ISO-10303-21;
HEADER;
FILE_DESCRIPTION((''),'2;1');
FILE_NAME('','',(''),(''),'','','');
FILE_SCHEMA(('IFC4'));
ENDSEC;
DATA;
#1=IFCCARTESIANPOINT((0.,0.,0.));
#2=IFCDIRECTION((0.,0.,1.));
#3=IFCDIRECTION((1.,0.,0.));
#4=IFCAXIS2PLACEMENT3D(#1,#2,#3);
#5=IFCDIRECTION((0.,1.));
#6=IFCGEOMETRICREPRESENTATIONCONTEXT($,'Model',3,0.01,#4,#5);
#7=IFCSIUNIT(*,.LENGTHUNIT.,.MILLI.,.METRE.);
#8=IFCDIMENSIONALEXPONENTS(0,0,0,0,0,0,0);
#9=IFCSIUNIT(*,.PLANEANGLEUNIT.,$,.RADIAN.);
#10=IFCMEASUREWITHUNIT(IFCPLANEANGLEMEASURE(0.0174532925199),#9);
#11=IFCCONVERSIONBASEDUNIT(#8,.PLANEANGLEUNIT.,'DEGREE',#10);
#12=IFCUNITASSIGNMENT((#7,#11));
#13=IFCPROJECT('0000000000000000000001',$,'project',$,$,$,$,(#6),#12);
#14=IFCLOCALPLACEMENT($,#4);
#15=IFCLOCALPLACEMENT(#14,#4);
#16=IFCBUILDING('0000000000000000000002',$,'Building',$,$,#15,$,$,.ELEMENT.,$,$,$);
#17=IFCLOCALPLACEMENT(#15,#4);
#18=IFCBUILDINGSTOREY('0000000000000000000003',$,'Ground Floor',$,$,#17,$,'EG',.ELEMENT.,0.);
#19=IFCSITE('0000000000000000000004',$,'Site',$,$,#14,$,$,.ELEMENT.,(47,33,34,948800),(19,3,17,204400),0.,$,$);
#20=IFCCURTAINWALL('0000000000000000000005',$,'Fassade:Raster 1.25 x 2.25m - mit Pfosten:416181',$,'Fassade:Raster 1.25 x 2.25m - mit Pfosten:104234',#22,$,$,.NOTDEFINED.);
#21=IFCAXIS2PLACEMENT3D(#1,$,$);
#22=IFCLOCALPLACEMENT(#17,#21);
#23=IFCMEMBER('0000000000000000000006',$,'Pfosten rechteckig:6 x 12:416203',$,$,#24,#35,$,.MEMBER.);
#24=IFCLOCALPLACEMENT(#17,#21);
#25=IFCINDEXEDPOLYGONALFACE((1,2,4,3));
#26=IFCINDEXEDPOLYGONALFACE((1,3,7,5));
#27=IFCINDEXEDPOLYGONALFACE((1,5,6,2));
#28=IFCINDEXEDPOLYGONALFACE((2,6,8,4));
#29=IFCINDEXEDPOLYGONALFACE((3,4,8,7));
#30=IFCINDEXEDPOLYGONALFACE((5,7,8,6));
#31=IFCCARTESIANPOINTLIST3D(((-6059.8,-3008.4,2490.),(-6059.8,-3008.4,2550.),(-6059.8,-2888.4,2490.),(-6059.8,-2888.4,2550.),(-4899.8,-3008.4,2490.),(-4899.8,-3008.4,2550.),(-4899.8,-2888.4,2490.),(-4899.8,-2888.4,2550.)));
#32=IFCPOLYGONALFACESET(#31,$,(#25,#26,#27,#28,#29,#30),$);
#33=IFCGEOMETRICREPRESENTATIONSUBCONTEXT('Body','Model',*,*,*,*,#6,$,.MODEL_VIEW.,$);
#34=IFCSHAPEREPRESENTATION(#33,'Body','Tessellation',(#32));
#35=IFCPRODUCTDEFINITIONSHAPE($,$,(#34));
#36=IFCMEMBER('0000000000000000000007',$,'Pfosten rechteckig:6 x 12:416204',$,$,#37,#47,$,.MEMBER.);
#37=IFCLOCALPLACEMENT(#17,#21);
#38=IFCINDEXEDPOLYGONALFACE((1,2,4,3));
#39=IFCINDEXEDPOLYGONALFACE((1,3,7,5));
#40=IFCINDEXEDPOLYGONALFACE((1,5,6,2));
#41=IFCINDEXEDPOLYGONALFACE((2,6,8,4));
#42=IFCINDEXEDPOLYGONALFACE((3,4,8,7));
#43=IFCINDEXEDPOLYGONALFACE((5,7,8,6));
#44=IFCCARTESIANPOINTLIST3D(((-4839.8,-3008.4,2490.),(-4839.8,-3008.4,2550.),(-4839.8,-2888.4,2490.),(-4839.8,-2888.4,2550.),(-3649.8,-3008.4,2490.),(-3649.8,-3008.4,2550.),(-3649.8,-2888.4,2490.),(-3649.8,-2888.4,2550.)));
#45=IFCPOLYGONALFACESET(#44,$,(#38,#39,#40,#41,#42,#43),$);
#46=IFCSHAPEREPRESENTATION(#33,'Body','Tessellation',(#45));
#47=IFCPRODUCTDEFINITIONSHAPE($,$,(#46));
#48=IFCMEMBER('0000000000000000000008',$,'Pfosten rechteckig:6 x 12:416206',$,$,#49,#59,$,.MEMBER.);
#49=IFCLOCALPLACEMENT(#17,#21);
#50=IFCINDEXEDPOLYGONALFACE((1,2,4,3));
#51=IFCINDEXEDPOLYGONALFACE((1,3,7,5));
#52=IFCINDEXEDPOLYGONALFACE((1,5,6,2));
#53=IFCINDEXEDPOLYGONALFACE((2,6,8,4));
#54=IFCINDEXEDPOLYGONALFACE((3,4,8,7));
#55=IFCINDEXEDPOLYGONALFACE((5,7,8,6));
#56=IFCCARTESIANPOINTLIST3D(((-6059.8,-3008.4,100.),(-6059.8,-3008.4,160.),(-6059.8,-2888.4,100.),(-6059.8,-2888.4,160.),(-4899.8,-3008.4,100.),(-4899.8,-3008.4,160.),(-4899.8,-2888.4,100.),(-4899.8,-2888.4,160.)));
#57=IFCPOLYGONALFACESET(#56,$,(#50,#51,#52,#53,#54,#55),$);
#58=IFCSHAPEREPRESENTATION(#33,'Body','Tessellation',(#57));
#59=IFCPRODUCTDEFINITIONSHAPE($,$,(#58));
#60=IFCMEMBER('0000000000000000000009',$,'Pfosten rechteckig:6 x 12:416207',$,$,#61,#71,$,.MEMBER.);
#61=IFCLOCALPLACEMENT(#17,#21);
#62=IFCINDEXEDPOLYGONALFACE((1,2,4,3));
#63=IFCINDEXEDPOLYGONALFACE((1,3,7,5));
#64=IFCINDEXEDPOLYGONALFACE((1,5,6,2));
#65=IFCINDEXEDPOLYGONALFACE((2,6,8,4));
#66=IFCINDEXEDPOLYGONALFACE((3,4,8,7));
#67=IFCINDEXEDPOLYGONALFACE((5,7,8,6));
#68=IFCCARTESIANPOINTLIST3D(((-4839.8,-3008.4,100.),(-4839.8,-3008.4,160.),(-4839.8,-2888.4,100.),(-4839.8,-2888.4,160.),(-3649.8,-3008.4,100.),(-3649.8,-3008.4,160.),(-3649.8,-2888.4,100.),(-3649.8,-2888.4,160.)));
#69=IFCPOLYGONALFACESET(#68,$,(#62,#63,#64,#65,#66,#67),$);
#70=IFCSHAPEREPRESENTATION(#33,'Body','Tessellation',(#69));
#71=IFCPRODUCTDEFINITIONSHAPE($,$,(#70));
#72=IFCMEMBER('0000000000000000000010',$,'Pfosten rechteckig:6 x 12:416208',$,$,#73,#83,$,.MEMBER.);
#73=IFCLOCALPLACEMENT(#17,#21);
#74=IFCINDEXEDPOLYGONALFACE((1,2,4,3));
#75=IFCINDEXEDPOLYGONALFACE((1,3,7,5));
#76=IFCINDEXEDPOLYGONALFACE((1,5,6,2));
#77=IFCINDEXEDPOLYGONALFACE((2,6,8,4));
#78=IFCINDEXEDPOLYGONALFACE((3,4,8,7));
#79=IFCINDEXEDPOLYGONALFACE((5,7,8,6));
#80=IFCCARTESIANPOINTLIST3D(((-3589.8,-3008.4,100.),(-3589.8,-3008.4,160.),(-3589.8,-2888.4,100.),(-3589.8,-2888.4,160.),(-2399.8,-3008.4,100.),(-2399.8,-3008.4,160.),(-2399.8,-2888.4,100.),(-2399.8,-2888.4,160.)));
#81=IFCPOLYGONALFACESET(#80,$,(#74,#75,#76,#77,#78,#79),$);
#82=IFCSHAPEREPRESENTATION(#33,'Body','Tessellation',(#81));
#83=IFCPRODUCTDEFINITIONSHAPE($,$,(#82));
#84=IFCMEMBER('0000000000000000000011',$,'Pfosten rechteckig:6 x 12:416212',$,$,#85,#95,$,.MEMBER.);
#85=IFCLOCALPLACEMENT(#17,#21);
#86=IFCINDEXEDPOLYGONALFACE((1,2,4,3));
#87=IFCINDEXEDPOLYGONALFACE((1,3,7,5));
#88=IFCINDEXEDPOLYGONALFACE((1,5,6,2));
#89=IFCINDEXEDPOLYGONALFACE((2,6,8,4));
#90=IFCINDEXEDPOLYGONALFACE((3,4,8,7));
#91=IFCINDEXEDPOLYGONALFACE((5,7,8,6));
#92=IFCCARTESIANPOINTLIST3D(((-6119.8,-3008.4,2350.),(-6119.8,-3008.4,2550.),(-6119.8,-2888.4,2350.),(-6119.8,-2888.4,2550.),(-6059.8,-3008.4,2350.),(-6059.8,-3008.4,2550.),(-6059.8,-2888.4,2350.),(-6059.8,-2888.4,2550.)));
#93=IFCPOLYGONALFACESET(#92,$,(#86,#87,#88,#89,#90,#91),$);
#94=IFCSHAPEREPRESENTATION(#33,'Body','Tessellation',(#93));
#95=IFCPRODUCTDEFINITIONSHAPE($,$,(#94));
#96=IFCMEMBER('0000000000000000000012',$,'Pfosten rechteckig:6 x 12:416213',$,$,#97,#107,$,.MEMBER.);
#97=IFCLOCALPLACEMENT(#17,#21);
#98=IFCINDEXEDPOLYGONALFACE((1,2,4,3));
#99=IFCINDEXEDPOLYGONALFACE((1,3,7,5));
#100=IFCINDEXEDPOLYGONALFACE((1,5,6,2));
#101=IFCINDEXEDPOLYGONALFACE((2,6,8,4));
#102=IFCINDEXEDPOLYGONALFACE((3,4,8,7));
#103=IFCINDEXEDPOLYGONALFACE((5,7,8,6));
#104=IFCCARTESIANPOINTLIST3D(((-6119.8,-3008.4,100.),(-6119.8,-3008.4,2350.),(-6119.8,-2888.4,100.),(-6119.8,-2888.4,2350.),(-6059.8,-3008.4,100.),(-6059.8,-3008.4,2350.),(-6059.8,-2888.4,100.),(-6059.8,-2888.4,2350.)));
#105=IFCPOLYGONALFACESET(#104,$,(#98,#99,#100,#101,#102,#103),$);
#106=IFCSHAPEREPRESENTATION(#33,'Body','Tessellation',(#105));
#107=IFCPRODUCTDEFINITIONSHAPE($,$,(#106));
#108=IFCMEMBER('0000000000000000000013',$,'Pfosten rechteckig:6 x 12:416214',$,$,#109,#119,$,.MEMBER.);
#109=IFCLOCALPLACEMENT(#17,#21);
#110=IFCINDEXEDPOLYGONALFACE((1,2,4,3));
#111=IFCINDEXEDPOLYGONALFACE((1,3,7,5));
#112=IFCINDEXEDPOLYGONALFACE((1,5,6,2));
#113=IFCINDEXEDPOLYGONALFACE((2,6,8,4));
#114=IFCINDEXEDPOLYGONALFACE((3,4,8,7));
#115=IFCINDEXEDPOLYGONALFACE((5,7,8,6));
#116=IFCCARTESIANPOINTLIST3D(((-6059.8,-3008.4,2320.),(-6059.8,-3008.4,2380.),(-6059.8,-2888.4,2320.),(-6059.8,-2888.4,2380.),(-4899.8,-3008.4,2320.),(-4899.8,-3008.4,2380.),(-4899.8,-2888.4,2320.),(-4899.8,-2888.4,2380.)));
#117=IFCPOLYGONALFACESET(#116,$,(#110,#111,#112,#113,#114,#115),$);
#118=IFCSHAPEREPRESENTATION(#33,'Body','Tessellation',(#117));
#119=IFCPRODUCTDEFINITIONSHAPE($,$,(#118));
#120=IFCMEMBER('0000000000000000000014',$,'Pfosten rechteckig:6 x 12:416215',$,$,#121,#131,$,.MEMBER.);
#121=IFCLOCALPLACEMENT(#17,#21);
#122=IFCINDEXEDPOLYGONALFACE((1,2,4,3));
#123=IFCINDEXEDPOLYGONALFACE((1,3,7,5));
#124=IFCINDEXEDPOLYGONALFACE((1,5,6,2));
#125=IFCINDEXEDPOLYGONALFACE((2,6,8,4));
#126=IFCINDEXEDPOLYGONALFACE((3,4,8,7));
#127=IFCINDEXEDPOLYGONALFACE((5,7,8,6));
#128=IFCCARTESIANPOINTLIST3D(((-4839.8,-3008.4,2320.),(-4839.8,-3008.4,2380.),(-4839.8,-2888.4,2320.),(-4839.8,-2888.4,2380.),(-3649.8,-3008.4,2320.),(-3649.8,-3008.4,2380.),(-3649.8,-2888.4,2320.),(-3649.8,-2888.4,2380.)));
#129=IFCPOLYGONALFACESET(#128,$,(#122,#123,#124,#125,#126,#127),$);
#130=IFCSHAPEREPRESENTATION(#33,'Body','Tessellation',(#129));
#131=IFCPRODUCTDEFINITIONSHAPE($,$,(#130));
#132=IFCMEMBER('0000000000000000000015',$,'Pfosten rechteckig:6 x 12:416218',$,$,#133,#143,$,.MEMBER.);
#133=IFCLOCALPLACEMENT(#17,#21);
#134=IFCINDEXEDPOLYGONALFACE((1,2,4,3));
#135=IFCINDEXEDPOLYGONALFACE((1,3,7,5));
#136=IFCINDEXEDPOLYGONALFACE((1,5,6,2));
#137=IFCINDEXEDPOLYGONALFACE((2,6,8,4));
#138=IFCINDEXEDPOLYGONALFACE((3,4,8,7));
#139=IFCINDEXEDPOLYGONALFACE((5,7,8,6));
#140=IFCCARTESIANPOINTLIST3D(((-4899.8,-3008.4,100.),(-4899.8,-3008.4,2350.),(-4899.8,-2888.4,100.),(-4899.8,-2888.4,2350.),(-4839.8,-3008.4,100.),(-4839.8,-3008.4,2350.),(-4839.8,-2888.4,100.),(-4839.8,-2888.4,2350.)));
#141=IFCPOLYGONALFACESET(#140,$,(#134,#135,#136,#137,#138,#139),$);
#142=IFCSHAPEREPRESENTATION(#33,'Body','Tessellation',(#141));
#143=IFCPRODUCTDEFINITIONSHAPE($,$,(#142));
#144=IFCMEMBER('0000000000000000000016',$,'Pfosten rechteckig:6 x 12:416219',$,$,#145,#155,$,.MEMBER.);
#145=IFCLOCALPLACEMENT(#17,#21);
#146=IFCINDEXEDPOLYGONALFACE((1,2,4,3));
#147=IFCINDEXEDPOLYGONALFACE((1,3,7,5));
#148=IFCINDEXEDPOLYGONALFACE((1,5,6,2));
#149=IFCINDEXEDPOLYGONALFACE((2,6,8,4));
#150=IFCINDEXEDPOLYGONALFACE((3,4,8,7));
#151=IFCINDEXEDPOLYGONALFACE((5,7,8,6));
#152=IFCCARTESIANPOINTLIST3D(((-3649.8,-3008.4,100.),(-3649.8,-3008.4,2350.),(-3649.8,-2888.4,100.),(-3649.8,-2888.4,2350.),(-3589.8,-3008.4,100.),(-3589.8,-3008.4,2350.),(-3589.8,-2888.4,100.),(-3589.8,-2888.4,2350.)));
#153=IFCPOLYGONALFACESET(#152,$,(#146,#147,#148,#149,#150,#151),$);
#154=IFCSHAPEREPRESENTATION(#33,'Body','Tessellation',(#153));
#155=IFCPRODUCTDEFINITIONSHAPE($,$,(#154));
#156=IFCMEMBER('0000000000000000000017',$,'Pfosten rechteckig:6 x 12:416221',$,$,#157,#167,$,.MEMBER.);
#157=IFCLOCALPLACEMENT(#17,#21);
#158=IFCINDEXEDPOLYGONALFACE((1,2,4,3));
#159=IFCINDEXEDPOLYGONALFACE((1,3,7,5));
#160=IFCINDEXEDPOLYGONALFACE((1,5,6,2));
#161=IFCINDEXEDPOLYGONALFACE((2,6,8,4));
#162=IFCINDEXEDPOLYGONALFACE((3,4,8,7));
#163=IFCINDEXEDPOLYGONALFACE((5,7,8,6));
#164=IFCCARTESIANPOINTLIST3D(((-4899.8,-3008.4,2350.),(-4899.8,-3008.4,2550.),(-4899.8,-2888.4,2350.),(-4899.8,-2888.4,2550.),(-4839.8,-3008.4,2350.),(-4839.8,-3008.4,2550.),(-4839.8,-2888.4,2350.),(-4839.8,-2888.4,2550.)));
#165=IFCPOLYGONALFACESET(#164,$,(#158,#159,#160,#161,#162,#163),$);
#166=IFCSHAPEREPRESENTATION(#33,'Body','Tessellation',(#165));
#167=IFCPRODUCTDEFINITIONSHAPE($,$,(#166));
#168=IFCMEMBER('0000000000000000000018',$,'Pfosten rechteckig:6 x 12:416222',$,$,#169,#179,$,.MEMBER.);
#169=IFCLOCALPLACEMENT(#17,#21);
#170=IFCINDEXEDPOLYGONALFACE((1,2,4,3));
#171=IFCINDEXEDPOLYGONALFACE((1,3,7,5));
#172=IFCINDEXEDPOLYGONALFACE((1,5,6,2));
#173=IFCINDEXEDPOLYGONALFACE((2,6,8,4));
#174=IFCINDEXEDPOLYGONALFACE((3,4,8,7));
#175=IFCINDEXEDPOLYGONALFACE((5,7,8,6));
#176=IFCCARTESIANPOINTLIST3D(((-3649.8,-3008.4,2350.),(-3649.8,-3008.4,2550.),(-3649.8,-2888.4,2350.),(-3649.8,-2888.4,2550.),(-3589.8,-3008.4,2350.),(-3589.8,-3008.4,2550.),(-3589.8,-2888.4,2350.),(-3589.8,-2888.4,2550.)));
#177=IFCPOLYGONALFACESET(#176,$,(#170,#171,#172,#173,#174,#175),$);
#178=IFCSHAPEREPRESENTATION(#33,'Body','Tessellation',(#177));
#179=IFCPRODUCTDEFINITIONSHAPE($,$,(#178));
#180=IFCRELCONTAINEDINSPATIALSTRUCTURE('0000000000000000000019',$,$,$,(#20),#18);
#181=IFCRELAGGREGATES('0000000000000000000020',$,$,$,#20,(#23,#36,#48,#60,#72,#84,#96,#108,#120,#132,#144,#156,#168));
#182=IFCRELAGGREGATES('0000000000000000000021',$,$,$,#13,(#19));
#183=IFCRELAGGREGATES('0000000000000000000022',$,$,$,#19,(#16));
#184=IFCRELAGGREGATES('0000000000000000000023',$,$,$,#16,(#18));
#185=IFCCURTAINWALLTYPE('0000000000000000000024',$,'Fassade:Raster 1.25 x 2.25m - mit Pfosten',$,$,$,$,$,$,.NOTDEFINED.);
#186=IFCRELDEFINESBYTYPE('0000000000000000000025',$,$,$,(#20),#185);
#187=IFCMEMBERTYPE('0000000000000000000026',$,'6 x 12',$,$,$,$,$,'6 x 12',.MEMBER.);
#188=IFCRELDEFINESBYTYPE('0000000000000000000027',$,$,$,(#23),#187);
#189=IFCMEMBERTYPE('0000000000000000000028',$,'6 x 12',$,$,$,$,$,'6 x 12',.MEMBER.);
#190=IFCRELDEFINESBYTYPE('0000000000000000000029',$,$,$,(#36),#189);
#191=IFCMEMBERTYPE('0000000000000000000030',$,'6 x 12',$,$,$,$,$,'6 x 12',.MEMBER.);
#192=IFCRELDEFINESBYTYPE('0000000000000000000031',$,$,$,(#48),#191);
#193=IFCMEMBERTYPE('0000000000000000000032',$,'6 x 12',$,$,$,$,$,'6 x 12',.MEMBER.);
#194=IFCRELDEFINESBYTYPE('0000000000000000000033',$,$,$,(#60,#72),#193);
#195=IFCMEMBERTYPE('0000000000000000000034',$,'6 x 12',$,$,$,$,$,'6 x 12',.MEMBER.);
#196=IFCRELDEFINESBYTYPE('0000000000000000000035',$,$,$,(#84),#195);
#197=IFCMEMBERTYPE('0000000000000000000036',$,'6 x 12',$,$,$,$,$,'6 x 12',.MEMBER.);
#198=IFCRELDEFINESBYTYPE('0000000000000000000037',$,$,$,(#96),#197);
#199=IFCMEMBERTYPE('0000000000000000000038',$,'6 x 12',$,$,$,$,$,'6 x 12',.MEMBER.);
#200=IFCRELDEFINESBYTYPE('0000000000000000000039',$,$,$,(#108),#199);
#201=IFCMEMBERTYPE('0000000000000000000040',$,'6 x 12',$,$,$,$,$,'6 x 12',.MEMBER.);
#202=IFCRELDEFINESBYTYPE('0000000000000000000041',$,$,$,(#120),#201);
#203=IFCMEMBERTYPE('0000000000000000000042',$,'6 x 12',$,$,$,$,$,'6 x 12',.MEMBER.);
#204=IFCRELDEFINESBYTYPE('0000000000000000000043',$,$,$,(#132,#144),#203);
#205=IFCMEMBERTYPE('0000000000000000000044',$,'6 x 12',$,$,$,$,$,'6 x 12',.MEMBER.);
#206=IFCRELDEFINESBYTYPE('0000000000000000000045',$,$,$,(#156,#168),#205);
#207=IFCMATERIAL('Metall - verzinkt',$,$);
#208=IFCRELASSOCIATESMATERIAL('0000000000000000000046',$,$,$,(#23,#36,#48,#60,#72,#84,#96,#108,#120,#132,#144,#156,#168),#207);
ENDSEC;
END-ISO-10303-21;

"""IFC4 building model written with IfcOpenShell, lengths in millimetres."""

from ifc_helpers import new_model, entity, si_unit, converted_unit, direction, frame, origin_with_axes, origin_2d_with_axis, place, context, subcontext, project, spatial, rectangle, extrude, material, type_object, element, aggregate, save


model = new_model("IFC4")

# Units and contexts
model_context = context("Model", 3, precision=0.01, world=origin_with_axes(), true_north=direction((0.0, 1.0)))
body_context = subcontext(model_context, "Body", "Model", "MODEL_VIEW")
ifc_project = project(units=[si_unit("LENGTHUNIT", "METRE", prefix="MILLI"), converted_unit("PLANEANGLEUNIT", "DEGREE", entity("IfcPlaneAngleMeasure", 0.0174532925199), si_unit("PLANEANGLEUNIT", "RADIAN"), dimensions=[0, 0, 0, 0, 0, 0, 0])], contexts=[model_context])

# Site, building, storey
site_placement = place(None, origin_with_axes())
site = spatial("IfcSite", under=ifc_project, at=site_placement, Name="Site", CompositionType="ELEMENT", RefLatitude=(47, 33, 34, 948800), RefLongitude=(19, 3, 17, 204400), RefElevation=0.0)
building_placement = place(site_placement, origin_with_axes())
building = spatial("IfcBuilding", under=site, at=building_placement, Name="Building", CompositionType="ELEMENT")
storey_placement = place(building_placement, origin_with_axes())
storey = spatial("IfcBuildingStorey", under=building, at=storey_placement, Name="Ground Floor", LongName="EG", CompositionType="ELEMENT", Elevation=0.0)

# Curtain wall, members
curtain_wall_type = type_object("IfcCurtainWallType", Name="Fassade:Raster 1.25 x 2.25m - mit Pfosten", PredefinedType="NOTDEFINED")
curtain_wall_placement = place(storey_placement, origin_with_axes())
curtain_wall = element("IfcCurtainWall", 1, at=curtain_wall_placement, inside=storey, type_object=curtain_wall_type, Name="Fassade:Raster 1.25 x 2.25m - mit Pfosten:416181", ObjectType="Fassade:Raster 1.25 x 2.25m - mit Pfosten:104234", PredefinedType="NOTDEFINED")
ifc_material_1 = material(Name="Metall - verzinkt")
member_type_1 = type_object("IfcMemberType", Name="6 x 12", ElementType="6 x 12", PredefinedType="MEMBER")
member_1_placement = place(curtain_wall_placement, frame((-4899.8, -2948.4, 2550.0), z_axis=(0.0, 0.0, 1.0), x_axis=(0.0, -1.0, 0.0)))
member_1 = element("IfcMember", 2, at=member_1_placement, type_object=member_type_1, material=ifc_material_1, Name="Pfosten rechteckig:6 x 12:416203", PredefinedType="MEMBER", context=body_context, shape_type="SweptSolid", body=[
    extrude(rectangle(XDim=120.0, YDim=60.0, at=origin_2d_with_axis()), frame((0.0, -1160.0, -30.0), z_axis=(0.0, 1.0, 0.0), x_axis=(-1.0, 0.0, 0.0)), (0.0, 0.0, 1.0), 1160.0),
])
member_type_2 = type_object("IfcMemberType", Name="6 x 12", ElementType="6 x 12", PredefinedType="MEMBER")
member_2_placement = place(curtain_wall_placement, frame((-3649.8, -2948.4, 2550.0), z_axis=(0.0, 0.0, 1.0), x_axis=(0.0, -1.0, 0.0)))
member_2 = element("IfcMember", 3, at=member_2_placement, type_object=member_type_2, material=ifc_material_1, Name="Pfosten rechteckig:6 x 12:416204", PredefinedType="MEMBER", context=body_context, shape_type="SweptSolid", body=[
    extrude(rectangle(XDim=120.0, YDim=60.0, at=origin_2d_with_axis()), frame((0.0, -1190.0, -30.0), z_axis=(0.0, 1.0, 0.0), x_axis=(-1.0, 0.0, 0.0)), (0.0, 0.0, 1.0), 1190.0),
])
member_type_3 = type_object("IfcMemberType", Name="6 x 12", ElementType="6 x 12", PredefinedType="MEMBER")
member_3_placement = place(curtain_wall_placement, frame((-6059.8, -2948.4, 100.0), z_axis=(0.0, 0.0, 1.0), x_axis=(0.0, -1.0, 0.0)))
member_3 = element("IfcMember", 4, at=member_3_placement, type_object=member_type_3, material=ifc_material_1, Name="Pfosten rechteckig:6 x 12:416206", PredefinedType="MEMBER", context=body_context, shape_type="SweptSolid", body=[
    extrude(rectangle(XDim=120.0, YDim=60.0, at=origin_2d_with_axis()), frame((0.0, 1160.0, 30.0), z_axis=(0.0, -1.0, 0.0), x_axis=(-1.0, 0.0, 0.0)), (0.0, 0.0, 1.0), 1160.0),
])
member_type_4 = type_object("IfcMemberType", Name="6 x 12", ElementType="6 x 12", PredefinedType="MEMBER")
member_4_placement = place(curtain_wall_placement, frame((-4839.8, -2948.4, 100.0), z_axis=(0.0, 0.0, 1.0), x_axis=(0.0, -1.0, 0.0)))
member_4 = element("IfcMember", 5, at=member_4_placement, type_object=member_type_4, material=ifc_material_1, Name="Pfosten rechteckig:6 x 12:416207", PredefinedType="MEMBER", context=body_context, shape_type="SweptSolid", body=[
    extrude(rectangle(XDim=120.0, YDim=60.0, at=origin_2d_with_axis()), frame((0.0, 1190.0, 30.0), z_axis=(0.0, -1.0, 0.0), x_axis=(-1.0, 0.0, 0.0)), (0.0, 0.0, 1.0), 1190.0),
])
member_5_placement = place(curtain_wall_placement, frame((-3589.8, -2948.4, 100.0), z_axis=(0.0, 0.0, 1.0), x_axis=(0.0, -1.0, 0.0)))
member_5 = element("IfcMember", 6, at=member_5_placement, type_object=member_type_4, material=ifc_material_1, Name="Pfosten rechteckig:6 x 12:416208", PredefinedType="MEMBER", context=body_context, shape_type="SweptSolid", body=[
    extrude(rectangle(XDim=120.0, YDim=60.0, at=origin_2d_with_axis()), frame((0.0, 1190.0, 30.0), z_axis=(0.0, -1.0, 0.0), x_axis=(-1.0, 0.0, 0.0)), (0.0, 0.0, 1.0), 1190.0),
])
member_type_5 = type_object("IfcMemberType", Name="6 x 12", ElementType="6 x 12", PredefinedType="MEMBER")
member_6_placement = place(curtain_wall_placement, frame((-6119.8, -2948.4, 2550.0), z_axis=(0.0, 0.0, 1.0), x_axis=(-1.0, 0.0, 0.0)))
member_6 = element("IfcMember", 7, at=member_6_placement, type_object=member_type_5, material=ifc_material_1, Name="Pfosten rechteckig:6 x 12:416212", PredefinedType="MEMBER", context=body_context, shape_type="SweptSolid", body=[
    extrude(rectangle(XDim=120.0, YDim=60.0, at=origin_2d_with_axis()), frame((-30.0, 0.0, -200.0), z_axis=(0.0, 0.0, 1.0), x_axis=(0.0, -1.0, 0.0)), (0.0, 0.0, 1.0), 200.0),
])
member_type_6 = type_object("IfcMemberType", Name="6 x 12", ElementType="6 x 12", PredefinedType="MEMBER")
member_7_placement = place(curtain_wall_placement, frame((-6119.8, -2948.4, 2350.0), z_axis=(0.0, 0.0, 1.0), x_axis=(-1.0, 0.0, 0.0)))
member_7 = element("IfcMember", 8, at=member_7_placement, type_object=member_type_6, material=ifc_material_1, Name="Pfosten rechteckig:6 x 12:416213", PredefinedType="MEMBER", context=body_context, shape_type="SweptSolid", body=[
    extrude(rectangle(XDim=120.0, YDim=60.0, at=origin_2d_with_axis()), frame((-30.0, 0.0, -2250.0), z_axis=(0.0, 0.0, 1.0), x_axis=(0.0, -1.0, 0.0)), (0.0, 0.0, 1.0), 2250.0),
])
member_type_7 = type_object("IfcMemberType", Name="6 x 12", ElementType="6 x 12", PredefinedType="MEMBER")
member_8_placement = place(curtain_wall_placement, frame((-4899.8, -2948.4, 2350.0), z_axis=(0.0, 0.0, 1.0), x_axis=(0.0, -1.0, 0.0)))
member_8 = element("IfcMember", 9, at=member_8_placement, type_object=member_type_7, material=ifc_material_1, Name="Pfosten rechteckig:6 x 12:416214", PredefinedType="MEMBER", context=body_context, shape_type="SweptSolid", body=[
    extrude(rectangle(XDim=120.0, YDim=60.0, at=origin_2d_with_axis()), frame((0.0, -1160.0, 0.0), z_axis=(0.0, 1.0, 0.0), x_axis=(-1.0, 0.0, 0.0)), (0.0, 0.0, 1.0), 1160.0),
])
member_type_8 = type_object("IfcMemberType", Name="6 x 12", ElementType="6 x 12", PredefinedType="MEMBER")
member_9_placement = place(curtain_wall_placement, frame((-3649.8, -2948.4, 2350.0), z_axis=(0.0, 0.0, 1.0), x_axis=(0.0, -1.0, 0.0)))
member_9 = element("IfcMember", 10, at=member_9_placement, type_object=member_type_8, material=ifc_material_1, Name="Pfosten rechteckig:6 x 12:416215", PredefinedType="MEMBER", context=body_context, shape_type="SweptSolid", body=[
    extrude(rectangle(XDim=120.0, YDim=60.0, at=origin_2d_with_axis()), frame((0.0, -1190.0, 0.0), z_axis=(0.0, 1.0, 0.0), x_axis=(-1.0, 0.0, 0.0)), (0.0, 0.0, 1.0), 1190.0),
])
member_type_9 = type_object("IfcMemberType", Name="6 x 12", ElementType="6 x 12", PredefinedType="MEMBER")
member_10_placement = place(curtain_wall_placement, frame((-4869.8, -2948.4, 100.0), z_axis=(0.0, 0.0, 1.0), x_axis=(1.0, 0.0, 0.0)))
member_10 = element("IfcMember", 11, at=member_10_placement, type_object=member_type_9, material=ifc_material_1, Name="Pfosten rechteckig:6 x 12:416218", PredefinedType="MEMBER", context=body_context, shape_type="SweptSolid", body=[
    extrude(rectangle(XDim=120.0, YDim=60.0, at=origin_2d_with_axis()), frame((0.0, 0.0, 2250.0), z_axis=(0.0, 0.0, -1.0), x_axis=(0.0, 1.0, 0.0)), (0.0, 0.0, 1.0), 2250.0),
])
member_11_placement = place(curtain_wall_placement, frame((-3619.8, -2948.4, 100.0), z_axis=(0.0, 0.0, 1.0), x_axis=(1.0, 0.0, 0.0)))
member_11 = element("IfcMember", 12, at=member_11_placement, type_object=member_type_9, material=ifc_material_1, Name="Pfosten rechteckig:6 x 12:416219", PredefinedType="MEMBER", context=body_context, shape_type="SweptSolid", body=[
    extrude(rectangle(XDim=120.0, YDim=60.0, at=origin_2d_with_axis()), frame((0.0, 0.0, 2250.0), z_axis=(0.0, 0.0, -1.0), x_axis=(0.0, 1.0, 0.0)), (0.0, 0.0, 1.0), 2250.0),
])
member_type_10 = type_object("IfcMemberType", Name="6 x 12", ElementType="6 x 12", PredefinedType="MEMBER")
member_12_placement = place(curtain_wall_placement, frame((-4869.8, -2948.4, 2350.0), z_axis=(0.0, 0.0, 1.0), x_axis=(1.0, 0.0, 0.0)))
member_12 = element("IfcMember", 13, at=member_12_placement, type_object=member_type_10, material=ifc_material_1, Name="Pfosten rechteckig:6 x 12:416221", PredefinedType="MEMBER", context=body_context, shape_type="SweptSolid", body=[
    extrude(rectangle(XDim=120.0, YDim=60.0, at=origin_2d_with_axis()), frame((0.0, 0.0, 200.0), z_axis=(0.0, 0.0, -1.0), x_axis=(0.0, 1.0, 0.0)), (0.0, 0.0, 1.0), 200.0),
])
member_13_placement = place(curtain_wall_placement, frame((-3619.8, -2948.4, 2350.0), z_axis=(0.0, 0.0, 1.0), x_axis=(1.0, 0.0, 0.0)))
member_13 = element("IfcMember", 14, at=member_13_placement, type_object=member_type_10, material=ifc_material_1, Name="Pfosten rechteckig:6 x 12:416222", PredefinedType="MEMBER", context=body_context, shape_type="SweptSolid", body=[
    extrude(rectangle(XDim=120.0, YDim=60.0, at=origin_2d_with_axis()), frame((0.0, 0.0, 200.0), z_axis=(0.0, 0.0, -1.0), x_axis=(0.0, 1.0, 0.0)), (0.0, 0.0, 1.0), 200.0),
])

aggregate(curtain_wall, [member_1, member_2, member_3, member_4, member_5, member_6, member_7, member_8, member_9, member_10, member_11, member_12, member_13])

save(model, "model.ifc")
